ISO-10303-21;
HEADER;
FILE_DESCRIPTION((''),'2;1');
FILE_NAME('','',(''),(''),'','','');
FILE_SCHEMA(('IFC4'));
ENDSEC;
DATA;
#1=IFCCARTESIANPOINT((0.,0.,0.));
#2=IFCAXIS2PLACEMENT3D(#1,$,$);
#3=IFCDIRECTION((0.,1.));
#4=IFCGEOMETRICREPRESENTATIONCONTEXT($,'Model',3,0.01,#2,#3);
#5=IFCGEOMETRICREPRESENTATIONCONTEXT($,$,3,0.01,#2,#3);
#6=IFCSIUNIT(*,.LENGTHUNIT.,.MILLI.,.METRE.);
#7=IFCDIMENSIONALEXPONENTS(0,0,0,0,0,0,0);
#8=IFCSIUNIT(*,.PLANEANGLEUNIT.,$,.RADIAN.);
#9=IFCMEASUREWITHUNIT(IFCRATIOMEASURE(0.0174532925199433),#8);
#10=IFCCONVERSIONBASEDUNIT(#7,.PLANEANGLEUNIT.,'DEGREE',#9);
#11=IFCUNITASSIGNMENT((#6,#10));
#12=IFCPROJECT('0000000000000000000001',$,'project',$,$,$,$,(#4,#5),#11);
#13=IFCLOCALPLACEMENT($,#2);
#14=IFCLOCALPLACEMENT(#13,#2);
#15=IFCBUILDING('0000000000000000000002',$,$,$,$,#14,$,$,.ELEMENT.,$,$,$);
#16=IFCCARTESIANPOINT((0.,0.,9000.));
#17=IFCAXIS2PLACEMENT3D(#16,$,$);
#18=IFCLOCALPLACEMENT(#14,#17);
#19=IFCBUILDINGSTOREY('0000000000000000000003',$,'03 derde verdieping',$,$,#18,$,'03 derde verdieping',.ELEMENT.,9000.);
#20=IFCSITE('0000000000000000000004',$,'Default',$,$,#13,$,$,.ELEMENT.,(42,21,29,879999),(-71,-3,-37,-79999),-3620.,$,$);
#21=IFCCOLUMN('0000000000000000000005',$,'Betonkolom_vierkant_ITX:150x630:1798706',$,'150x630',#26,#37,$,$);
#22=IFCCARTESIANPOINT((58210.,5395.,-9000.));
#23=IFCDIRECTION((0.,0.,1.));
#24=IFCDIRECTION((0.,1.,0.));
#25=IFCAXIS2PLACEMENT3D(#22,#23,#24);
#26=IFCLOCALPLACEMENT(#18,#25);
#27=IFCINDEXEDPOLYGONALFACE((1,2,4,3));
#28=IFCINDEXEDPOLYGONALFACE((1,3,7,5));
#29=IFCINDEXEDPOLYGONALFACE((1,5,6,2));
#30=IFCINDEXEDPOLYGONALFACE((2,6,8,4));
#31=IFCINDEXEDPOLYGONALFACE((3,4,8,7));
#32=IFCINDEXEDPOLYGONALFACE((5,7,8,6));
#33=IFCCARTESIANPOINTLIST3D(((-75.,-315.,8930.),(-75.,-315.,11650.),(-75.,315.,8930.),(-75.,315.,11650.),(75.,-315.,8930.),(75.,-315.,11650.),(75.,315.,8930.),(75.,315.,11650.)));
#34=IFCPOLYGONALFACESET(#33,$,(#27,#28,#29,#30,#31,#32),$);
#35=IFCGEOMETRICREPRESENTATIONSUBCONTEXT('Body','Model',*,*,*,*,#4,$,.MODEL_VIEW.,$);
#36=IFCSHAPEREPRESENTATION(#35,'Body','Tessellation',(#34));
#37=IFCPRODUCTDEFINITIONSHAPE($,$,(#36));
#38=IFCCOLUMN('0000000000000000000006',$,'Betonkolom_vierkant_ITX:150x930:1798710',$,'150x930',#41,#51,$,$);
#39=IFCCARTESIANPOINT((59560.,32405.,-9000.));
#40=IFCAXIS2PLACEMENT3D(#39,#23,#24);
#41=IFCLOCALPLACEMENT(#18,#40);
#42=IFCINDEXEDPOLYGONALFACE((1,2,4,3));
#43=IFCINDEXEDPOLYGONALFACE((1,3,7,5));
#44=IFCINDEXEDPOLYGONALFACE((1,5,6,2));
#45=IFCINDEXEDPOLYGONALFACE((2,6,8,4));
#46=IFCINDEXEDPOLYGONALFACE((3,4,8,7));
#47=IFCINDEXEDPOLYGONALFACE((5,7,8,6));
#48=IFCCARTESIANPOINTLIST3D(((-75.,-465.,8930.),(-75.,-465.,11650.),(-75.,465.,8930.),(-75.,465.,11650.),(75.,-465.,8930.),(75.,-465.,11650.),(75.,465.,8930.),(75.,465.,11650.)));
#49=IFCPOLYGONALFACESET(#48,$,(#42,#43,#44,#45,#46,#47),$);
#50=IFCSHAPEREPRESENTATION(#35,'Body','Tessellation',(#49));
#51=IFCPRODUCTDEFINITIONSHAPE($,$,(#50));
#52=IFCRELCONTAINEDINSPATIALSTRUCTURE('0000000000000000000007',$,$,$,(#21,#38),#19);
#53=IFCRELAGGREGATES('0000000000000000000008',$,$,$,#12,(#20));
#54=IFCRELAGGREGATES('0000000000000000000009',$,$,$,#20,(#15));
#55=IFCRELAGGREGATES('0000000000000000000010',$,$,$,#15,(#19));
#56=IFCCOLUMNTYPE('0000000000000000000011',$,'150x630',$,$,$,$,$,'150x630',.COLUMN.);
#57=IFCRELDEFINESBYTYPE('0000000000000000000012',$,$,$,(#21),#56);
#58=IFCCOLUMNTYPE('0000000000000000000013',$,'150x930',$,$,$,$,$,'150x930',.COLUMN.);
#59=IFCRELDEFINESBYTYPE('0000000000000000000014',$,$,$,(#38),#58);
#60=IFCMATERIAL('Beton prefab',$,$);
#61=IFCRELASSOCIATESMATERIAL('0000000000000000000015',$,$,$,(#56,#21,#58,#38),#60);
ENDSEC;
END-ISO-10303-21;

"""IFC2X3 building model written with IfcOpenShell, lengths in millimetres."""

from ifc_helpers import new_model, entity, si_unit, converted_unit, direction, frame, origin, origin_2d_with_axis, place, context, subcontext, project, spatial, rectangle, extrude, source, transform, mapped, material, type_object, type_shapes, element, save


model = new_model("IFC2X3")

# Units and contexts
model_context = context("Model", 3, precision=0.01, world=origin(), true_north=direction((0.0, 1.0)))
context_of_model = context(None, 3, precision=0.01, world=origin(), true_north=direction((0.0, 1.0)))
body_context = subcontext(model_context, "Body", "Model", "MODEL_VIEW")
ifc_project = project(units=[si_unit("LENGTHUNIT", "METRE", prefix="MILLI"), converted_unit("PLANEANGLEUNIT", "DEGREE", entity("IfcRatioMeasure", 0.0174532925199433), si_unit("PLANEANGLEUNIT", "RADIAN"), dimensions=[0, 0, 0, 0, 0, 0, 0])], contexts=[model_context, context_of_model])

# Site, building, storey
site_placement = place(None, origin())
site = spatial("IfcSite", under=ifc_project, at=site_placement, Name="Default", CompositionType="ELEMENT", RefLatitude=(42, 21, 29, 879999), RefLongitude=(-71, -3, -37, -79999), RefElevation=-3620.0)
building_placement = place(site_placement, origin())
building = spatial("IfcBuilding", under=site, at=building_placement, CompositionType="ELEMENT")
storey_placement = place(building_placement, frame((0.0, 0.0, 9000.0)))
storey = spatial("IfcBuildingStorey", under=building, at=storey_placement, Name="03 derde verdieping", LongName="03 derde verdieping", CompositionType="ELEMENT", Elevation=9000.0)

# Columns
ifc_material_1 = material(Name="Beton prefab")
column_type_1 = type_object("IfcColumnType", Name="150x630", ElementType="150x630", PredefinedType="COLUMN", material=ifc_material_1)
shared_shape_1 = source(origin(), body_context, "Body", "SweptSolid", [
    extrude(rectangle(XDim=630.0, YDim=150.0, at=origin_2d_with_axis()), frame((0.0, 0.0, 8930.0), z_axis=(0.0, 0.0, 1.0), x_axis=(0.0, -1.0, 0.0)), (0.0, 0.0, 1.0), 2720.0),
])
type_shapes(column_type_1, [shared_shape_1])
column_1_placement = place(storey_placement, frame((58210.0, 5395.0, -9000.0), z_axis=(0.0, 0.0, 1.0), x_axis=(0.0, 1.0, 0.0)))
element("IfcColumn", 1, at=column_1_placement, inside=storey, type_object=column_type_1, material=ifc_material_1, Name="Betonkolom_vierkant_ITX:150x630:1798706", ObjectType="150x630", context=body_context, shape_type="MappedRepresentation", body=[
    mapped(shared_shape_1, transform((0.0, 0.0, 0.0), scale=1.0)),
])
column_type_2 = type_object("IfcColumnType", Name="150x930", ElementType="150x930", PredefinedType="COLUMN", material=ifc_material_1)
shared_shape_2 = source(origin(), body_context, "Body", "SweptSolid", [
    extrude(rectangle(XDim=930.0, YDim=150.0, at=origin_2d_with_axis()), frame((0.0, 0.0, 8930.0), z_axis=(0.0, 0.0, 1.0), x_axis=(0.0, -1.0, 0.0)), (0.0, 0.0, 1.0), 2720.0),
])
type_shapes(column_type_2, [shared_shape_2])
column_2_placement = place(storey_placement, frame((59560.0, 32405.0, -9000.0), z_axis=(0.0, 0.0, 1.0), x_axis=(0.0, 1.0, 0.0)))
element("IfcColumn", 2, at=column_2_placement, inside=storey, type_object=column_type_2, material=ifc_material_1, Name="Betonkolom_vierkant_ITX:150x930:1798710", ObjectType="150x930", context=body_context, shape_type="MappedRepresentation", body=[
    mapped(shared_shape_2, transform((0.0, 0.0, 0.0), scale=1.0)),
])

save(model, "model.ifc")
